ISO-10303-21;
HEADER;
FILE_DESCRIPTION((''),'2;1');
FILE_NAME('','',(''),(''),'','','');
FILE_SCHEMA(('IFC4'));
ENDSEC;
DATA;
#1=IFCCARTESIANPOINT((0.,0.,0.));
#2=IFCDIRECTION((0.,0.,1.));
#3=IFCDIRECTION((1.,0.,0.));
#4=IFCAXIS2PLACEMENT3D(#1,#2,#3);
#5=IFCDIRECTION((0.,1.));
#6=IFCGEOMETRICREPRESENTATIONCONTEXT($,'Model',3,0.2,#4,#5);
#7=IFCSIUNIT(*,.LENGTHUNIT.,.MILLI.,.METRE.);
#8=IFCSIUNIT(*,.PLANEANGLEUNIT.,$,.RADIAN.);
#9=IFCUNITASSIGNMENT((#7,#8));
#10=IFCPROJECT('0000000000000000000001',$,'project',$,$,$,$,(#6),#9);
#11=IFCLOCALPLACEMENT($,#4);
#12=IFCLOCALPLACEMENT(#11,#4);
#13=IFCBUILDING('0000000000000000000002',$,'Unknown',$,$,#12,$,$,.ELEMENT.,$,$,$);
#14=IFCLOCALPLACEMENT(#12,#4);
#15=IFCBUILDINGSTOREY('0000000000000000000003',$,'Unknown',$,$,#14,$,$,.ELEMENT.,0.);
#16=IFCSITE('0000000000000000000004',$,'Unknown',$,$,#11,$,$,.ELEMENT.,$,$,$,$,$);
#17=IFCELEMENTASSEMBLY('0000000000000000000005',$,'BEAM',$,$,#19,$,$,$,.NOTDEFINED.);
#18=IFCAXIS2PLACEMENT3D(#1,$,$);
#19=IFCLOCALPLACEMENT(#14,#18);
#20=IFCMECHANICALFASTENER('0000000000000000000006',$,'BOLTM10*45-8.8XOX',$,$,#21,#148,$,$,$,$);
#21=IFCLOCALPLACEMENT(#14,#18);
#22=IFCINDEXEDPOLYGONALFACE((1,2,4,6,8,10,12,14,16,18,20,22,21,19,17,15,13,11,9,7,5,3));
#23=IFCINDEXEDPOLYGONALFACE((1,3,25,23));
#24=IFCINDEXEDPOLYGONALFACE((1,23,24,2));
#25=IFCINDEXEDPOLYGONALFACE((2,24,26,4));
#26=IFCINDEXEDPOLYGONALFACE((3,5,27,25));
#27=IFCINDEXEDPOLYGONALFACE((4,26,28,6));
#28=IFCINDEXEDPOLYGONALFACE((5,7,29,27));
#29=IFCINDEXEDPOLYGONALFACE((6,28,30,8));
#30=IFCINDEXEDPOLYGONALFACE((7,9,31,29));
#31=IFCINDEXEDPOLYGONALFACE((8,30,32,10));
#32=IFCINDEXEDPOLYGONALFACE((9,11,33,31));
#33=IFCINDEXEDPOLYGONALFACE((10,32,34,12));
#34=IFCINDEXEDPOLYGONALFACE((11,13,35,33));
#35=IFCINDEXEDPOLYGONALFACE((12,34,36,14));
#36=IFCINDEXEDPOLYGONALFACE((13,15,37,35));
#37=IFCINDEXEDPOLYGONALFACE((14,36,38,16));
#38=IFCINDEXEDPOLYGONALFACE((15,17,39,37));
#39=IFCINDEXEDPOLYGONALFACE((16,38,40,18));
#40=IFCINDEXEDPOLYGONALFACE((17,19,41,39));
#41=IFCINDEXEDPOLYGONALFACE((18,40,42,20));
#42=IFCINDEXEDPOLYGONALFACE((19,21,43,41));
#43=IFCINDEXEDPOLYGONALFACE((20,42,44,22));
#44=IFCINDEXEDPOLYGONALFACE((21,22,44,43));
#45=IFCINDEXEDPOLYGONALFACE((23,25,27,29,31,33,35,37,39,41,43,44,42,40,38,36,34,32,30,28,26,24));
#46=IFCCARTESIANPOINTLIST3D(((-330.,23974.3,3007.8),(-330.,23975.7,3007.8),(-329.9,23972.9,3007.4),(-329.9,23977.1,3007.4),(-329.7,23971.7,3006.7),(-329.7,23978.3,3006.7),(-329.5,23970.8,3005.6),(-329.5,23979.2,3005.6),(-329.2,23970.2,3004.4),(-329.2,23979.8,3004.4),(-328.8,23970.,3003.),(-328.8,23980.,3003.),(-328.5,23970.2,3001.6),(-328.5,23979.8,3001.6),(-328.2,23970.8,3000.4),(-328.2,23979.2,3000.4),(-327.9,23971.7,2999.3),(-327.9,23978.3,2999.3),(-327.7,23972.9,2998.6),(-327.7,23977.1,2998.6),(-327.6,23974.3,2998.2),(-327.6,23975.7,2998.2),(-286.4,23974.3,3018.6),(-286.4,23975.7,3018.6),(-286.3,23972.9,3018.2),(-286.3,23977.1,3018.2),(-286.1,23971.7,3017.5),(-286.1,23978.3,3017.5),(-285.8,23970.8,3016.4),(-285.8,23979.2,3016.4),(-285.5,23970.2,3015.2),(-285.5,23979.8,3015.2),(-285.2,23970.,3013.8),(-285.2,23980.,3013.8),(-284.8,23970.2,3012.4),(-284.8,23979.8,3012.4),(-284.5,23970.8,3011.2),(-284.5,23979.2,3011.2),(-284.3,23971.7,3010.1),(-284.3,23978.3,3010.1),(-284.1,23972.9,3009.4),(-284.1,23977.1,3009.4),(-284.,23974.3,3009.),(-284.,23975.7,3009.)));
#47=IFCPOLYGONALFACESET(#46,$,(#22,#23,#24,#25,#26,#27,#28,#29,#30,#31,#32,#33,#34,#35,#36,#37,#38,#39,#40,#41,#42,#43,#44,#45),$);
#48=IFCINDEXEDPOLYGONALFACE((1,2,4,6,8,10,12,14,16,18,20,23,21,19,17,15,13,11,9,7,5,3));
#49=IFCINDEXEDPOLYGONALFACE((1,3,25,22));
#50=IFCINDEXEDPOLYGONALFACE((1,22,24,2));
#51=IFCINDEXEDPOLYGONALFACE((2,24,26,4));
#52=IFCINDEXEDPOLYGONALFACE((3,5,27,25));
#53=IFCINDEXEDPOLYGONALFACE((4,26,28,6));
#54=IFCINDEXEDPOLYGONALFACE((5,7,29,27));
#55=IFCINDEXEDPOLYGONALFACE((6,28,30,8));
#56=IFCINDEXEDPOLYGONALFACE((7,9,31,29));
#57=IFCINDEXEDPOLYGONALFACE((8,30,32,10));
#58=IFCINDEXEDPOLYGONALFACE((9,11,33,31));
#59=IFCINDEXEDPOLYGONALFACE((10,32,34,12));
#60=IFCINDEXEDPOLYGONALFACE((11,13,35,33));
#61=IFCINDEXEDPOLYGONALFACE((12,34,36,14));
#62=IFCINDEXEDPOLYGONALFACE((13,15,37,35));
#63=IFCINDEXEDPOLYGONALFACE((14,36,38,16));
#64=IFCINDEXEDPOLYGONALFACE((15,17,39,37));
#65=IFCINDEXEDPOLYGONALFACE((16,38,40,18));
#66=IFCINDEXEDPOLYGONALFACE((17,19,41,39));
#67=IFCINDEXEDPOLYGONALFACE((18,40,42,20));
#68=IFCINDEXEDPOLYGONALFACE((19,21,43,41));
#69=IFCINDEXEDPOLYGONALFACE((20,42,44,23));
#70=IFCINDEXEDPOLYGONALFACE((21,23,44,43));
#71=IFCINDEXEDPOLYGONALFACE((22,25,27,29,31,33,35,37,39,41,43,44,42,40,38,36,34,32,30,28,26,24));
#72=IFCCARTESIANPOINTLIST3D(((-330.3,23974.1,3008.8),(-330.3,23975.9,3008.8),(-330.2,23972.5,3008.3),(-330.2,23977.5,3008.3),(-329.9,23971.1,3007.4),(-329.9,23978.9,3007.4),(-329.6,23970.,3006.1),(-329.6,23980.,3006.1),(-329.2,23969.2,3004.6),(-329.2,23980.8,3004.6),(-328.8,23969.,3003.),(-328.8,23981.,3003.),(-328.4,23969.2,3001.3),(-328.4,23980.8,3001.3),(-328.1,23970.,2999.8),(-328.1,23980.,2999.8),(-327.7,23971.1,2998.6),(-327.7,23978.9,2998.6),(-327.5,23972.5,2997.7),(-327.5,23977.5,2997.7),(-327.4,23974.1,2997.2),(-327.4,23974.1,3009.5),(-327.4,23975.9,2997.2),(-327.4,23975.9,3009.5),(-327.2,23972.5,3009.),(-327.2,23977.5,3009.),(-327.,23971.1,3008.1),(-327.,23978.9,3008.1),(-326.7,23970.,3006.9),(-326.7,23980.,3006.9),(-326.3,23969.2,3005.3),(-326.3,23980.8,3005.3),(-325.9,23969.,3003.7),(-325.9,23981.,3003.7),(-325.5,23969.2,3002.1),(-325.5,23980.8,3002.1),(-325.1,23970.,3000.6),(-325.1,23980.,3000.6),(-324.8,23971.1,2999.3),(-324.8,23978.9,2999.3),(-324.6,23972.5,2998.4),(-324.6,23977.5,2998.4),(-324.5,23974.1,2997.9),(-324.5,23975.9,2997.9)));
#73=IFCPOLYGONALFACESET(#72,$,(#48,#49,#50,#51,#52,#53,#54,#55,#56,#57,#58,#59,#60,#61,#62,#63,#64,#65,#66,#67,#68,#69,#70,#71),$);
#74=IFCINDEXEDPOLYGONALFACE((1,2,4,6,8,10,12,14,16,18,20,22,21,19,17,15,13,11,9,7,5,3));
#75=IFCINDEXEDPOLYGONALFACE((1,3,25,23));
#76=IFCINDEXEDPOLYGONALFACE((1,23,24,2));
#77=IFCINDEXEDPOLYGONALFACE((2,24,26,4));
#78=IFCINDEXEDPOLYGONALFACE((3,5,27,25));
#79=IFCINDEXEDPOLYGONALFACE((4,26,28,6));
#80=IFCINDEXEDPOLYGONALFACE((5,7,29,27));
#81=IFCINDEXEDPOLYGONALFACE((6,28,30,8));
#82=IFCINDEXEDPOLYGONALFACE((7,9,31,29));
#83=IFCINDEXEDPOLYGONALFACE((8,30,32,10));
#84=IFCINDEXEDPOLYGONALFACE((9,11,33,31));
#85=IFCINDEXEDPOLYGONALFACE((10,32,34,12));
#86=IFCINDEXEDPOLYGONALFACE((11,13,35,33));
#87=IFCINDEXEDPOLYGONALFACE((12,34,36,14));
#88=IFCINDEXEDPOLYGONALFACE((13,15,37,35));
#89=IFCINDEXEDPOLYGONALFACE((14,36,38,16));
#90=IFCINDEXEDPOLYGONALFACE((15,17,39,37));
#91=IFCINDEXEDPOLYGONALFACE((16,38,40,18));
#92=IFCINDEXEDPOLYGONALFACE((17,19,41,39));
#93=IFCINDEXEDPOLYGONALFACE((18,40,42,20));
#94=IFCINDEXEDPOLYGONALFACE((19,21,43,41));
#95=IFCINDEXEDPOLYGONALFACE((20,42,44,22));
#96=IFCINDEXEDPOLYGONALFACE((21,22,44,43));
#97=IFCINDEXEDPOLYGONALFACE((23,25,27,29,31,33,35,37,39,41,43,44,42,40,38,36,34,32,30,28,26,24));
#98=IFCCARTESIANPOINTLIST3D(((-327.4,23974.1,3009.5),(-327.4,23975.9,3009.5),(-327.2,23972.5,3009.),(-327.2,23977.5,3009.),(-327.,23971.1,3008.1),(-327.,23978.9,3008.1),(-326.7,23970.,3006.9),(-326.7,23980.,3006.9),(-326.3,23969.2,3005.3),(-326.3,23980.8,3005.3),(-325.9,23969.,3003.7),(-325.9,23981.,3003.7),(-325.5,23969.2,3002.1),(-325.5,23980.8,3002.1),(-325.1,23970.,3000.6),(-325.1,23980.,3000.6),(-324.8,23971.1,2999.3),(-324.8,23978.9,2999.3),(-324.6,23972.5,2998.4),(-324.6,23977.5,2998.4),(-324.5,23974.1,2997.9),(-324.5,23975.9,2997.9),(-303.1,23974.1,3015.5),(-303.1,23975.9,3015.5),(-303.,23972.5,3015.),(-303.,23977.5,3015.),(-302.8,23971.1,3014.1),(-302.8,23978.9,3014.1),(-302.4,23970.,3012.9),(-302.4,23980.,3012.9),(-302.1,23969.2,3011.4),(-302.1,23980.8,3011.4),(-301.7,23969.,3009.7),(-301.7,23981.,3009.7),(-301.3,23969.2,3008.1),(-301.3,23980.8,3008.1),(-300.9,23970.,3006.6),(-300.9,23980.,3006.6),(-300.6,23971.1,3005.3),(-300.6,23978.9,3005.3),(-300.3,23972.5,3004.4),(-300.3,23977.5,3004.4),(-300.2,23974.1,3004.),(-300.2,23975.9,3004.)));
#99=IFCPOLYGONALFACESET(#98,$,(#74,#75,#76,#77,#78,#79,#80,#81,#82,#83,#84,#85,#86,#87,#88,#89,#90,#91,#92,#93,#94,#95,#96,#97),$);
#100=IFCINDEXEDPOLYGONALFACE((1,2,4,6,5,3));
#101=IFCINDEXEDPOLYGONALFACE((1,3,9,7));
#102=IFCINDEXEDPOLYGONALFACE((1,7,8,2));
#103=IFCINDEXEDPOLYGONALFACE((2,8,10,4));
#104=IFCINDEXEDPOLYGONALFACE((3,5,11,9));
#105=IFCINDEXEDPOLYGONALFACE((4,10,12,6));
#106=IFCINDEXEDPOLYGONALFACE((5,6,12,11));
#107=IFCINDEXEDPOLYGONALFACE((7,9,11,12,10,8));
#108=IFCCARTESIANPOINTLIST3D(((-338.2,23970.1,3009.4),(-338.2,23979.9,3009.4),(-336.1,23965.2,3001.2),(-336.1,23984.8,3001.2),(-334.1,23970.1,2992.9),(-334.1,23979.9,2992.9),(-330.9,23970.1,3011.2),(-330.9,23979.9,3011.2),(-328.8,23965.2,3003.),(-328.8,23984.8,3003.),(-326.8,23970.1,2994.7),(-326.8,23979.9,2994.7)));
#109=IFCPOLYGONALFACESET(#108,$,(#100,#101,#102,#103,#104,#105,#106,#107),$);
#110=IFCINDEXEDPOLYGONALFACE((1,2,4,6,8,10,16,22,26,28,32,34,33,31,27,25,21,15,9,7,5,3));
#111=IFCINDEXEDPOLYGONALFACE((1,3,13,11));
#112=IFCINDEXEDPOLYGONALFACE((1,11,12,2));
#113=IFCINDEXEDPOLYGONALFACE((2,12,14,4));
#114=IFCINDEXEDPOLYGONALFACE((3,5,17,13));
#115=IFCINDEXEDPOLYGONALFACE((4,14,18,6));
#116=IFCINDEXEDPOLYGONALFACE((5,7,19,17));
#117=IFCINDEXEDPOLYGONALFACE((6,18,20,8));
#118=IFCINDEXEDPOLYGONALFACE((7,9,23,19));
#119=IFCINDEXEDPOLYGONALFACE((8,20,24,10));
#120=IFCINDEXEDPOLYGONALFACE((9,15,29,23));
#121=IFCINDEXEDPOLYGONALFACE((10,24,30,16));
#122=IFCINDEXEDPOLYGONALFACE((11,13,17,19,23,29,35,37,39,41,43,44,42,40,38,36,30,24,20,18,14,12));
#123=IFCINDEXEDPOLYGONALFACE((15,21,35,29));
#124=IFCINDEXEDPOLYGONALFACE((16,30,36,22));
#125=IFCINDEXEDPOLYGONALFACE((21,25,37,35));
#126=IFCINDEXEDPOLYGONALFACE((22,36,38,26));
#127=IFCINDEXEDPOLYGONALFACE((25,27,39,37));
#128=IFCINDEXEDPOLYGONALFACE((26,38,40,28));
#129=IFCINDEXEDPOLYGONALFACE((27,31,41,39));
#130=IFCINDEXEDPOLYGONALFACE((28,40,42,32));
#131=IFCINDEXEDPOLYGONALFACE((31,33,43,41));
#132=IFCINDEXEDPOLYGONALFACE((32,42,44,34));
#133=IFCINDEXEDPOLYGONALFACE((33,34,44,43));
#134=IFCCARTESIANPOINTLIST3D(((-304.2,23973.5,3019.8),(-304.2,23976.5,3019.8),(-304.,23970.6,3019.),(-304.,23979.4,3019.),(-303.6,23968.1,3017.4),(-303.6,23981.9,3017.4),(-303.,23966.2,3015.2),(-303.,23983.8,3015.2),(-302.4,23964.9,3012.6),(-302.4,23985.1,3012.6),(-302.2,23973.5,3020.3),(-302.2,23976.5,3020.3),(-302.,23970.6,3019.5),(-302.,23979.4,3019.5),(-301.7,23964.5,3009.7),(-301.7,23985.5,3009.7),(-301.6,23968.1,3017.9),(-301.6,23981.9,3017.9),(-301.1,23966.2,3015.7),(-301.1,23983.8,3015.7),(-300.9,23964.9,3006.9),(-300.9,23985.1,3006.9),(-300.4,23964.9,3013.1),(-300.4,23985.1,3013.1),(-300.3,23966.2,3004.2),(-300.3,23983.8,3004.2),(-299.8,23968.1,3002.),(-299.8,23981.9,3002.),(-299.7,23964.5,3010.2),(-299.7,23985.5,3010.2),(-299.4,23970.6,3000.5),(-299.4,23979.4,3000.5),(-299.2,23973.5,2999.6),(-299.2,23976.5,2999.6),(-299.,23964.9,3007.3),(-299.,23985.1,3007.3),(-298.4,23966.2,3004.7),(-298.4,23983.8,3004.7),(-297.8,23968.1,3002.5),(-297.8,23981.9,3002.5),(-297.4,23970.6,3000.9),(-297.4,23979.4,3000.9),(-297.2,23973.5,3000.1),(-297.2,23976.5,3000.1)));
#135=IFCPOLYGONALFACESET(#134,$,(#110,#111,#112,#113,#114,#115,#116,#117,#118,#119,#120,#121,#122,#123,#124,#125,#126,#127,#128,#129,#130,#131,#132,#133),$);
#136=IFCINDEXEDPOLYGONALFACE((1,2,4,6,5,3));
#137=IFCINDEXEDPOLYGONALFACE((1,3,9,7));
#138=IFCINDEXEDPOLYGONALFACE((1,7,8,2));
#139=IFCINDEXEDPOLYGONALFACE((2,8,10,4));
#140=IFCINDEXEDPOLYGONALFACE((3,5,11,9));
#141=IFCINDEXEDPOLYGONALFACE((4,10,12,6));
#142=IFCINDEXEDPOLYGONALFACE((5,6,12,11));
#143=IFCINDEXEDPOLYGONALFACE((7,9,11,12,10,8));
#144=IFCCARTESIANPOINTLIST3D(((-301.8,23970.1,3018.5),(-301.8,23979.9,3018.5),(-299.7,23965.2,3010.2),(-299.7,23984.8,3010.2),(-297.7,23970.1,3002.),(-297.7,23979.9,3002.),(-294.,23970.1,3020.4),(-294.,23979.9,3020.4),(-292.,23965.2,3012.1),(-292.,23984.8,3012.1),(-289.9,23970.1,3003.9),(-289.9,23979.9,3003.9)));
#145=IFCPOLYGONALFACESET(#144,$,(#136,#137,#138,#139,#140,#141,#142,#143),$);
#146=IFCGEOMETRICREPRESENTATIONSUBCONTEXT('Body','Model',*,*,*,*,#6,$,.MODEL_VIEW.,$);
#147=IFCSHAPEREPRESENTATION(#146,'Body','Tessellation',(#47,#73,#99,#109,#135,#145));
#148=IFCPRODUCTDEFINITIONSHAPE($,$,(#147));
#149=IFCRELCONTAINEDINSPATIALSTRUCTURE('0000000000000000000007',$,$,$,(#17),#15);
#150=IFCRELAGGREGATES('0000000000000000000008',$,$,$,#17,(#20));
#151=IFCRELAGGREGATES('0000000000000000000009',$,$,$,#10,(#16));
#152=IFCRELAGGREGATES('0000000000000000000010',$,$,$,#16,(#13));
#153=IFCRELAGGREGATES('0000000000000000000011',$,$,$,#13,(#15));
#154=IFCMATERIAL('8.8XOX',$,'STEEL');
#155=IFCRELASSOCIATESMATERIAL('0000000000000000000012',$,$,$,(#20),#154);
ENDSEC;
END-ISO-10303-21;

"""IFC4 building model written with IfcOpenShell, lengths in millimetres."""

from ifc_helpers import new_model, si_unit, direction, frame, origin_with_axes, place, context, subcontext, project, spatial, line, arc, indexed_curve, outline, extrude, source, transform, mapped, material, element, aggregate, save


model = new_model("IFC4")

# Units and contexts
model_context = context("Model", 3, precision=0.2, world=origin_with_axes(), true_north=direction((0.0, 1.0)))
body_context = subcontext(model_context, "Body", "Model", "MODEL_VIEW")
ifc_project = project(units=[si_unit("LENGTHUNIT", "METRE", prefix="MILLI"), si_unit("PLANEANGLEUNIT", "RADIAN")], contexts=[model_context])

# Site, building, storey
site_placement = place(None, origin_with_axes())
site = spatial("IfcSite", under=ifc_project, at=site_placement, Name="Unknown", CompositionType="ELEMENT")
building_placement = place(site_placement, origin_with_axes())
building = spatial("IfcBuilding", under=site, at=building_placement, Name="Unknown", CompositionType="ELEMENT")
storey_placement = place(building_placement, origin_with_axes())
storey = spatial("IfcBuildingStorey", under=building, at=storey_placement, Name="Unknown", CompositionType="ELEMENT", Elevation=0.0)

# Element assembly, mechanical fastener
ifc_material_1 = material(Name="8.8XOX", Category="STEEL")
shared_shape_1 = source(origin_with_axes(), body_context, "Body", "SweptSolid", [
    extrude(outline(indexed_curve([(5.0, 0.0), (0.0, 5.0), (-5.0, 0.0), (0.0, -5.0)], segments=[arc(1, 2, 3), arc(3, 4, 1)])), frame((0.0, 0.0, 3.8), z_axis=(0.0, 0.0, -1.0), x_axis=(0.0, 1.0, 0.0)), (0.0, 0.0, 1.0), 45.0),
    extrude(outline(indexed_curve([(6.0, 0.0), (0.0, 6.0), (-6.0, 0.0), (0.0, -6.0)], segments=[arc(1, 2, 3), arc(3, 4, 1)])), frame((0.0, 0.0, 3.8), z_axis=(0.0, 0.0, -1.0), x_axis=(0.0, 1.0, 0.0)), (0.0, 0.0, 1.0), 3.0),
    extrude(outline(indexed_curve([(6.0, 0.0), (0.0, 6.0), (-6.0, 0.0), (0.0, -6.0)], segments=[arc(1, 2, 3), arc(3, 4, 1)])), frame((0.0, 0.0, 0.8), z_axis=(0.0, 0.0, -1.0), x_axis=(0.0, 1.0, 0.0)), (0.0, 0.0, 1.0), 25.0),
    extrude(outline(indexed_curve([(9.8, 0.0), (4.9, 8.5), (-4.9, 8.5), (-9.8, 0.0), (-4.9, -8.5), (4.9, -8.5)], segments=[line(1, 2, 3, 4, 5, 6, 1)])), frame((0.0, 0.0, 11.2), z_axis=(0.0, 0.0, -1.0), x_axis=(0.0, 1.0, 0.0)), (0.0, 0.0, 1.0), 7.5),
    extrude(outline(indexed_curve([(10.5, 0.0), (0.0, 10.5), (-10.5, 0.0), (0.0, -10.5)], segments=[arc(1, 2, 3), arc(3, 4, 1)])), frame((0.0, 0.0, -24.2), z_axis=(0.0, 0.0, -1.0), x_axis=(0.0, 1.0, 0.0)), (0.0, 0.0, 1.0), 2.0),
    extrude(outline(indexed_curve([(9.8, 0.0), (4.9, 8.5), (-4.9, 8.5), (-9.8, 0.0), (-4.9, -8.5), (4.9, -8.5)], segments=[line(1, 2, 3, 4, 5, 6, 1)])), frame((0.0, 0.0, -26.2), z_axis=(0.0, 0.0, -1.0), x_axis=(0.0, 1.0, 0.0)), (0.0, 0.0, 1.0), 8.0),
])
assembly_1_placement = place(storey_placement, frame((-315.0, 18000.0, 3011.6), z_axis=(0.970613, 0.0, 0.240648), x_axis=(0.0, 1.0, 0.0)))
assembly_1 = element("IfcElementAssembly", 1, at=assembly_1_placement, inside=storey, Name="BEAM", PredefinedType="NOTDEFINED")
mechanical_fastener_1_placement = place(assembly_1_placement, frame((5975.0, -5.0, -11.8), z_axis=(0.0, 0.0, -1.0), x_axis=(0.0, 1.0, 0.0)))
mechanical_fastener_1 = element("IfcMechanicalFastener", 2, at=mechanical_fastener_1_placement, material=ifc_material_1, Name="BOLTM10*45-8.8XOX", context=body_context, shape_type="MappedRepresentation", body=[
    mapped(shared_shape_1, transform((0.0, 0.0, 0.0))),
])
aggregate(assembly_1, [mechanical_fastener_1])

save(model, "model.ifc")
